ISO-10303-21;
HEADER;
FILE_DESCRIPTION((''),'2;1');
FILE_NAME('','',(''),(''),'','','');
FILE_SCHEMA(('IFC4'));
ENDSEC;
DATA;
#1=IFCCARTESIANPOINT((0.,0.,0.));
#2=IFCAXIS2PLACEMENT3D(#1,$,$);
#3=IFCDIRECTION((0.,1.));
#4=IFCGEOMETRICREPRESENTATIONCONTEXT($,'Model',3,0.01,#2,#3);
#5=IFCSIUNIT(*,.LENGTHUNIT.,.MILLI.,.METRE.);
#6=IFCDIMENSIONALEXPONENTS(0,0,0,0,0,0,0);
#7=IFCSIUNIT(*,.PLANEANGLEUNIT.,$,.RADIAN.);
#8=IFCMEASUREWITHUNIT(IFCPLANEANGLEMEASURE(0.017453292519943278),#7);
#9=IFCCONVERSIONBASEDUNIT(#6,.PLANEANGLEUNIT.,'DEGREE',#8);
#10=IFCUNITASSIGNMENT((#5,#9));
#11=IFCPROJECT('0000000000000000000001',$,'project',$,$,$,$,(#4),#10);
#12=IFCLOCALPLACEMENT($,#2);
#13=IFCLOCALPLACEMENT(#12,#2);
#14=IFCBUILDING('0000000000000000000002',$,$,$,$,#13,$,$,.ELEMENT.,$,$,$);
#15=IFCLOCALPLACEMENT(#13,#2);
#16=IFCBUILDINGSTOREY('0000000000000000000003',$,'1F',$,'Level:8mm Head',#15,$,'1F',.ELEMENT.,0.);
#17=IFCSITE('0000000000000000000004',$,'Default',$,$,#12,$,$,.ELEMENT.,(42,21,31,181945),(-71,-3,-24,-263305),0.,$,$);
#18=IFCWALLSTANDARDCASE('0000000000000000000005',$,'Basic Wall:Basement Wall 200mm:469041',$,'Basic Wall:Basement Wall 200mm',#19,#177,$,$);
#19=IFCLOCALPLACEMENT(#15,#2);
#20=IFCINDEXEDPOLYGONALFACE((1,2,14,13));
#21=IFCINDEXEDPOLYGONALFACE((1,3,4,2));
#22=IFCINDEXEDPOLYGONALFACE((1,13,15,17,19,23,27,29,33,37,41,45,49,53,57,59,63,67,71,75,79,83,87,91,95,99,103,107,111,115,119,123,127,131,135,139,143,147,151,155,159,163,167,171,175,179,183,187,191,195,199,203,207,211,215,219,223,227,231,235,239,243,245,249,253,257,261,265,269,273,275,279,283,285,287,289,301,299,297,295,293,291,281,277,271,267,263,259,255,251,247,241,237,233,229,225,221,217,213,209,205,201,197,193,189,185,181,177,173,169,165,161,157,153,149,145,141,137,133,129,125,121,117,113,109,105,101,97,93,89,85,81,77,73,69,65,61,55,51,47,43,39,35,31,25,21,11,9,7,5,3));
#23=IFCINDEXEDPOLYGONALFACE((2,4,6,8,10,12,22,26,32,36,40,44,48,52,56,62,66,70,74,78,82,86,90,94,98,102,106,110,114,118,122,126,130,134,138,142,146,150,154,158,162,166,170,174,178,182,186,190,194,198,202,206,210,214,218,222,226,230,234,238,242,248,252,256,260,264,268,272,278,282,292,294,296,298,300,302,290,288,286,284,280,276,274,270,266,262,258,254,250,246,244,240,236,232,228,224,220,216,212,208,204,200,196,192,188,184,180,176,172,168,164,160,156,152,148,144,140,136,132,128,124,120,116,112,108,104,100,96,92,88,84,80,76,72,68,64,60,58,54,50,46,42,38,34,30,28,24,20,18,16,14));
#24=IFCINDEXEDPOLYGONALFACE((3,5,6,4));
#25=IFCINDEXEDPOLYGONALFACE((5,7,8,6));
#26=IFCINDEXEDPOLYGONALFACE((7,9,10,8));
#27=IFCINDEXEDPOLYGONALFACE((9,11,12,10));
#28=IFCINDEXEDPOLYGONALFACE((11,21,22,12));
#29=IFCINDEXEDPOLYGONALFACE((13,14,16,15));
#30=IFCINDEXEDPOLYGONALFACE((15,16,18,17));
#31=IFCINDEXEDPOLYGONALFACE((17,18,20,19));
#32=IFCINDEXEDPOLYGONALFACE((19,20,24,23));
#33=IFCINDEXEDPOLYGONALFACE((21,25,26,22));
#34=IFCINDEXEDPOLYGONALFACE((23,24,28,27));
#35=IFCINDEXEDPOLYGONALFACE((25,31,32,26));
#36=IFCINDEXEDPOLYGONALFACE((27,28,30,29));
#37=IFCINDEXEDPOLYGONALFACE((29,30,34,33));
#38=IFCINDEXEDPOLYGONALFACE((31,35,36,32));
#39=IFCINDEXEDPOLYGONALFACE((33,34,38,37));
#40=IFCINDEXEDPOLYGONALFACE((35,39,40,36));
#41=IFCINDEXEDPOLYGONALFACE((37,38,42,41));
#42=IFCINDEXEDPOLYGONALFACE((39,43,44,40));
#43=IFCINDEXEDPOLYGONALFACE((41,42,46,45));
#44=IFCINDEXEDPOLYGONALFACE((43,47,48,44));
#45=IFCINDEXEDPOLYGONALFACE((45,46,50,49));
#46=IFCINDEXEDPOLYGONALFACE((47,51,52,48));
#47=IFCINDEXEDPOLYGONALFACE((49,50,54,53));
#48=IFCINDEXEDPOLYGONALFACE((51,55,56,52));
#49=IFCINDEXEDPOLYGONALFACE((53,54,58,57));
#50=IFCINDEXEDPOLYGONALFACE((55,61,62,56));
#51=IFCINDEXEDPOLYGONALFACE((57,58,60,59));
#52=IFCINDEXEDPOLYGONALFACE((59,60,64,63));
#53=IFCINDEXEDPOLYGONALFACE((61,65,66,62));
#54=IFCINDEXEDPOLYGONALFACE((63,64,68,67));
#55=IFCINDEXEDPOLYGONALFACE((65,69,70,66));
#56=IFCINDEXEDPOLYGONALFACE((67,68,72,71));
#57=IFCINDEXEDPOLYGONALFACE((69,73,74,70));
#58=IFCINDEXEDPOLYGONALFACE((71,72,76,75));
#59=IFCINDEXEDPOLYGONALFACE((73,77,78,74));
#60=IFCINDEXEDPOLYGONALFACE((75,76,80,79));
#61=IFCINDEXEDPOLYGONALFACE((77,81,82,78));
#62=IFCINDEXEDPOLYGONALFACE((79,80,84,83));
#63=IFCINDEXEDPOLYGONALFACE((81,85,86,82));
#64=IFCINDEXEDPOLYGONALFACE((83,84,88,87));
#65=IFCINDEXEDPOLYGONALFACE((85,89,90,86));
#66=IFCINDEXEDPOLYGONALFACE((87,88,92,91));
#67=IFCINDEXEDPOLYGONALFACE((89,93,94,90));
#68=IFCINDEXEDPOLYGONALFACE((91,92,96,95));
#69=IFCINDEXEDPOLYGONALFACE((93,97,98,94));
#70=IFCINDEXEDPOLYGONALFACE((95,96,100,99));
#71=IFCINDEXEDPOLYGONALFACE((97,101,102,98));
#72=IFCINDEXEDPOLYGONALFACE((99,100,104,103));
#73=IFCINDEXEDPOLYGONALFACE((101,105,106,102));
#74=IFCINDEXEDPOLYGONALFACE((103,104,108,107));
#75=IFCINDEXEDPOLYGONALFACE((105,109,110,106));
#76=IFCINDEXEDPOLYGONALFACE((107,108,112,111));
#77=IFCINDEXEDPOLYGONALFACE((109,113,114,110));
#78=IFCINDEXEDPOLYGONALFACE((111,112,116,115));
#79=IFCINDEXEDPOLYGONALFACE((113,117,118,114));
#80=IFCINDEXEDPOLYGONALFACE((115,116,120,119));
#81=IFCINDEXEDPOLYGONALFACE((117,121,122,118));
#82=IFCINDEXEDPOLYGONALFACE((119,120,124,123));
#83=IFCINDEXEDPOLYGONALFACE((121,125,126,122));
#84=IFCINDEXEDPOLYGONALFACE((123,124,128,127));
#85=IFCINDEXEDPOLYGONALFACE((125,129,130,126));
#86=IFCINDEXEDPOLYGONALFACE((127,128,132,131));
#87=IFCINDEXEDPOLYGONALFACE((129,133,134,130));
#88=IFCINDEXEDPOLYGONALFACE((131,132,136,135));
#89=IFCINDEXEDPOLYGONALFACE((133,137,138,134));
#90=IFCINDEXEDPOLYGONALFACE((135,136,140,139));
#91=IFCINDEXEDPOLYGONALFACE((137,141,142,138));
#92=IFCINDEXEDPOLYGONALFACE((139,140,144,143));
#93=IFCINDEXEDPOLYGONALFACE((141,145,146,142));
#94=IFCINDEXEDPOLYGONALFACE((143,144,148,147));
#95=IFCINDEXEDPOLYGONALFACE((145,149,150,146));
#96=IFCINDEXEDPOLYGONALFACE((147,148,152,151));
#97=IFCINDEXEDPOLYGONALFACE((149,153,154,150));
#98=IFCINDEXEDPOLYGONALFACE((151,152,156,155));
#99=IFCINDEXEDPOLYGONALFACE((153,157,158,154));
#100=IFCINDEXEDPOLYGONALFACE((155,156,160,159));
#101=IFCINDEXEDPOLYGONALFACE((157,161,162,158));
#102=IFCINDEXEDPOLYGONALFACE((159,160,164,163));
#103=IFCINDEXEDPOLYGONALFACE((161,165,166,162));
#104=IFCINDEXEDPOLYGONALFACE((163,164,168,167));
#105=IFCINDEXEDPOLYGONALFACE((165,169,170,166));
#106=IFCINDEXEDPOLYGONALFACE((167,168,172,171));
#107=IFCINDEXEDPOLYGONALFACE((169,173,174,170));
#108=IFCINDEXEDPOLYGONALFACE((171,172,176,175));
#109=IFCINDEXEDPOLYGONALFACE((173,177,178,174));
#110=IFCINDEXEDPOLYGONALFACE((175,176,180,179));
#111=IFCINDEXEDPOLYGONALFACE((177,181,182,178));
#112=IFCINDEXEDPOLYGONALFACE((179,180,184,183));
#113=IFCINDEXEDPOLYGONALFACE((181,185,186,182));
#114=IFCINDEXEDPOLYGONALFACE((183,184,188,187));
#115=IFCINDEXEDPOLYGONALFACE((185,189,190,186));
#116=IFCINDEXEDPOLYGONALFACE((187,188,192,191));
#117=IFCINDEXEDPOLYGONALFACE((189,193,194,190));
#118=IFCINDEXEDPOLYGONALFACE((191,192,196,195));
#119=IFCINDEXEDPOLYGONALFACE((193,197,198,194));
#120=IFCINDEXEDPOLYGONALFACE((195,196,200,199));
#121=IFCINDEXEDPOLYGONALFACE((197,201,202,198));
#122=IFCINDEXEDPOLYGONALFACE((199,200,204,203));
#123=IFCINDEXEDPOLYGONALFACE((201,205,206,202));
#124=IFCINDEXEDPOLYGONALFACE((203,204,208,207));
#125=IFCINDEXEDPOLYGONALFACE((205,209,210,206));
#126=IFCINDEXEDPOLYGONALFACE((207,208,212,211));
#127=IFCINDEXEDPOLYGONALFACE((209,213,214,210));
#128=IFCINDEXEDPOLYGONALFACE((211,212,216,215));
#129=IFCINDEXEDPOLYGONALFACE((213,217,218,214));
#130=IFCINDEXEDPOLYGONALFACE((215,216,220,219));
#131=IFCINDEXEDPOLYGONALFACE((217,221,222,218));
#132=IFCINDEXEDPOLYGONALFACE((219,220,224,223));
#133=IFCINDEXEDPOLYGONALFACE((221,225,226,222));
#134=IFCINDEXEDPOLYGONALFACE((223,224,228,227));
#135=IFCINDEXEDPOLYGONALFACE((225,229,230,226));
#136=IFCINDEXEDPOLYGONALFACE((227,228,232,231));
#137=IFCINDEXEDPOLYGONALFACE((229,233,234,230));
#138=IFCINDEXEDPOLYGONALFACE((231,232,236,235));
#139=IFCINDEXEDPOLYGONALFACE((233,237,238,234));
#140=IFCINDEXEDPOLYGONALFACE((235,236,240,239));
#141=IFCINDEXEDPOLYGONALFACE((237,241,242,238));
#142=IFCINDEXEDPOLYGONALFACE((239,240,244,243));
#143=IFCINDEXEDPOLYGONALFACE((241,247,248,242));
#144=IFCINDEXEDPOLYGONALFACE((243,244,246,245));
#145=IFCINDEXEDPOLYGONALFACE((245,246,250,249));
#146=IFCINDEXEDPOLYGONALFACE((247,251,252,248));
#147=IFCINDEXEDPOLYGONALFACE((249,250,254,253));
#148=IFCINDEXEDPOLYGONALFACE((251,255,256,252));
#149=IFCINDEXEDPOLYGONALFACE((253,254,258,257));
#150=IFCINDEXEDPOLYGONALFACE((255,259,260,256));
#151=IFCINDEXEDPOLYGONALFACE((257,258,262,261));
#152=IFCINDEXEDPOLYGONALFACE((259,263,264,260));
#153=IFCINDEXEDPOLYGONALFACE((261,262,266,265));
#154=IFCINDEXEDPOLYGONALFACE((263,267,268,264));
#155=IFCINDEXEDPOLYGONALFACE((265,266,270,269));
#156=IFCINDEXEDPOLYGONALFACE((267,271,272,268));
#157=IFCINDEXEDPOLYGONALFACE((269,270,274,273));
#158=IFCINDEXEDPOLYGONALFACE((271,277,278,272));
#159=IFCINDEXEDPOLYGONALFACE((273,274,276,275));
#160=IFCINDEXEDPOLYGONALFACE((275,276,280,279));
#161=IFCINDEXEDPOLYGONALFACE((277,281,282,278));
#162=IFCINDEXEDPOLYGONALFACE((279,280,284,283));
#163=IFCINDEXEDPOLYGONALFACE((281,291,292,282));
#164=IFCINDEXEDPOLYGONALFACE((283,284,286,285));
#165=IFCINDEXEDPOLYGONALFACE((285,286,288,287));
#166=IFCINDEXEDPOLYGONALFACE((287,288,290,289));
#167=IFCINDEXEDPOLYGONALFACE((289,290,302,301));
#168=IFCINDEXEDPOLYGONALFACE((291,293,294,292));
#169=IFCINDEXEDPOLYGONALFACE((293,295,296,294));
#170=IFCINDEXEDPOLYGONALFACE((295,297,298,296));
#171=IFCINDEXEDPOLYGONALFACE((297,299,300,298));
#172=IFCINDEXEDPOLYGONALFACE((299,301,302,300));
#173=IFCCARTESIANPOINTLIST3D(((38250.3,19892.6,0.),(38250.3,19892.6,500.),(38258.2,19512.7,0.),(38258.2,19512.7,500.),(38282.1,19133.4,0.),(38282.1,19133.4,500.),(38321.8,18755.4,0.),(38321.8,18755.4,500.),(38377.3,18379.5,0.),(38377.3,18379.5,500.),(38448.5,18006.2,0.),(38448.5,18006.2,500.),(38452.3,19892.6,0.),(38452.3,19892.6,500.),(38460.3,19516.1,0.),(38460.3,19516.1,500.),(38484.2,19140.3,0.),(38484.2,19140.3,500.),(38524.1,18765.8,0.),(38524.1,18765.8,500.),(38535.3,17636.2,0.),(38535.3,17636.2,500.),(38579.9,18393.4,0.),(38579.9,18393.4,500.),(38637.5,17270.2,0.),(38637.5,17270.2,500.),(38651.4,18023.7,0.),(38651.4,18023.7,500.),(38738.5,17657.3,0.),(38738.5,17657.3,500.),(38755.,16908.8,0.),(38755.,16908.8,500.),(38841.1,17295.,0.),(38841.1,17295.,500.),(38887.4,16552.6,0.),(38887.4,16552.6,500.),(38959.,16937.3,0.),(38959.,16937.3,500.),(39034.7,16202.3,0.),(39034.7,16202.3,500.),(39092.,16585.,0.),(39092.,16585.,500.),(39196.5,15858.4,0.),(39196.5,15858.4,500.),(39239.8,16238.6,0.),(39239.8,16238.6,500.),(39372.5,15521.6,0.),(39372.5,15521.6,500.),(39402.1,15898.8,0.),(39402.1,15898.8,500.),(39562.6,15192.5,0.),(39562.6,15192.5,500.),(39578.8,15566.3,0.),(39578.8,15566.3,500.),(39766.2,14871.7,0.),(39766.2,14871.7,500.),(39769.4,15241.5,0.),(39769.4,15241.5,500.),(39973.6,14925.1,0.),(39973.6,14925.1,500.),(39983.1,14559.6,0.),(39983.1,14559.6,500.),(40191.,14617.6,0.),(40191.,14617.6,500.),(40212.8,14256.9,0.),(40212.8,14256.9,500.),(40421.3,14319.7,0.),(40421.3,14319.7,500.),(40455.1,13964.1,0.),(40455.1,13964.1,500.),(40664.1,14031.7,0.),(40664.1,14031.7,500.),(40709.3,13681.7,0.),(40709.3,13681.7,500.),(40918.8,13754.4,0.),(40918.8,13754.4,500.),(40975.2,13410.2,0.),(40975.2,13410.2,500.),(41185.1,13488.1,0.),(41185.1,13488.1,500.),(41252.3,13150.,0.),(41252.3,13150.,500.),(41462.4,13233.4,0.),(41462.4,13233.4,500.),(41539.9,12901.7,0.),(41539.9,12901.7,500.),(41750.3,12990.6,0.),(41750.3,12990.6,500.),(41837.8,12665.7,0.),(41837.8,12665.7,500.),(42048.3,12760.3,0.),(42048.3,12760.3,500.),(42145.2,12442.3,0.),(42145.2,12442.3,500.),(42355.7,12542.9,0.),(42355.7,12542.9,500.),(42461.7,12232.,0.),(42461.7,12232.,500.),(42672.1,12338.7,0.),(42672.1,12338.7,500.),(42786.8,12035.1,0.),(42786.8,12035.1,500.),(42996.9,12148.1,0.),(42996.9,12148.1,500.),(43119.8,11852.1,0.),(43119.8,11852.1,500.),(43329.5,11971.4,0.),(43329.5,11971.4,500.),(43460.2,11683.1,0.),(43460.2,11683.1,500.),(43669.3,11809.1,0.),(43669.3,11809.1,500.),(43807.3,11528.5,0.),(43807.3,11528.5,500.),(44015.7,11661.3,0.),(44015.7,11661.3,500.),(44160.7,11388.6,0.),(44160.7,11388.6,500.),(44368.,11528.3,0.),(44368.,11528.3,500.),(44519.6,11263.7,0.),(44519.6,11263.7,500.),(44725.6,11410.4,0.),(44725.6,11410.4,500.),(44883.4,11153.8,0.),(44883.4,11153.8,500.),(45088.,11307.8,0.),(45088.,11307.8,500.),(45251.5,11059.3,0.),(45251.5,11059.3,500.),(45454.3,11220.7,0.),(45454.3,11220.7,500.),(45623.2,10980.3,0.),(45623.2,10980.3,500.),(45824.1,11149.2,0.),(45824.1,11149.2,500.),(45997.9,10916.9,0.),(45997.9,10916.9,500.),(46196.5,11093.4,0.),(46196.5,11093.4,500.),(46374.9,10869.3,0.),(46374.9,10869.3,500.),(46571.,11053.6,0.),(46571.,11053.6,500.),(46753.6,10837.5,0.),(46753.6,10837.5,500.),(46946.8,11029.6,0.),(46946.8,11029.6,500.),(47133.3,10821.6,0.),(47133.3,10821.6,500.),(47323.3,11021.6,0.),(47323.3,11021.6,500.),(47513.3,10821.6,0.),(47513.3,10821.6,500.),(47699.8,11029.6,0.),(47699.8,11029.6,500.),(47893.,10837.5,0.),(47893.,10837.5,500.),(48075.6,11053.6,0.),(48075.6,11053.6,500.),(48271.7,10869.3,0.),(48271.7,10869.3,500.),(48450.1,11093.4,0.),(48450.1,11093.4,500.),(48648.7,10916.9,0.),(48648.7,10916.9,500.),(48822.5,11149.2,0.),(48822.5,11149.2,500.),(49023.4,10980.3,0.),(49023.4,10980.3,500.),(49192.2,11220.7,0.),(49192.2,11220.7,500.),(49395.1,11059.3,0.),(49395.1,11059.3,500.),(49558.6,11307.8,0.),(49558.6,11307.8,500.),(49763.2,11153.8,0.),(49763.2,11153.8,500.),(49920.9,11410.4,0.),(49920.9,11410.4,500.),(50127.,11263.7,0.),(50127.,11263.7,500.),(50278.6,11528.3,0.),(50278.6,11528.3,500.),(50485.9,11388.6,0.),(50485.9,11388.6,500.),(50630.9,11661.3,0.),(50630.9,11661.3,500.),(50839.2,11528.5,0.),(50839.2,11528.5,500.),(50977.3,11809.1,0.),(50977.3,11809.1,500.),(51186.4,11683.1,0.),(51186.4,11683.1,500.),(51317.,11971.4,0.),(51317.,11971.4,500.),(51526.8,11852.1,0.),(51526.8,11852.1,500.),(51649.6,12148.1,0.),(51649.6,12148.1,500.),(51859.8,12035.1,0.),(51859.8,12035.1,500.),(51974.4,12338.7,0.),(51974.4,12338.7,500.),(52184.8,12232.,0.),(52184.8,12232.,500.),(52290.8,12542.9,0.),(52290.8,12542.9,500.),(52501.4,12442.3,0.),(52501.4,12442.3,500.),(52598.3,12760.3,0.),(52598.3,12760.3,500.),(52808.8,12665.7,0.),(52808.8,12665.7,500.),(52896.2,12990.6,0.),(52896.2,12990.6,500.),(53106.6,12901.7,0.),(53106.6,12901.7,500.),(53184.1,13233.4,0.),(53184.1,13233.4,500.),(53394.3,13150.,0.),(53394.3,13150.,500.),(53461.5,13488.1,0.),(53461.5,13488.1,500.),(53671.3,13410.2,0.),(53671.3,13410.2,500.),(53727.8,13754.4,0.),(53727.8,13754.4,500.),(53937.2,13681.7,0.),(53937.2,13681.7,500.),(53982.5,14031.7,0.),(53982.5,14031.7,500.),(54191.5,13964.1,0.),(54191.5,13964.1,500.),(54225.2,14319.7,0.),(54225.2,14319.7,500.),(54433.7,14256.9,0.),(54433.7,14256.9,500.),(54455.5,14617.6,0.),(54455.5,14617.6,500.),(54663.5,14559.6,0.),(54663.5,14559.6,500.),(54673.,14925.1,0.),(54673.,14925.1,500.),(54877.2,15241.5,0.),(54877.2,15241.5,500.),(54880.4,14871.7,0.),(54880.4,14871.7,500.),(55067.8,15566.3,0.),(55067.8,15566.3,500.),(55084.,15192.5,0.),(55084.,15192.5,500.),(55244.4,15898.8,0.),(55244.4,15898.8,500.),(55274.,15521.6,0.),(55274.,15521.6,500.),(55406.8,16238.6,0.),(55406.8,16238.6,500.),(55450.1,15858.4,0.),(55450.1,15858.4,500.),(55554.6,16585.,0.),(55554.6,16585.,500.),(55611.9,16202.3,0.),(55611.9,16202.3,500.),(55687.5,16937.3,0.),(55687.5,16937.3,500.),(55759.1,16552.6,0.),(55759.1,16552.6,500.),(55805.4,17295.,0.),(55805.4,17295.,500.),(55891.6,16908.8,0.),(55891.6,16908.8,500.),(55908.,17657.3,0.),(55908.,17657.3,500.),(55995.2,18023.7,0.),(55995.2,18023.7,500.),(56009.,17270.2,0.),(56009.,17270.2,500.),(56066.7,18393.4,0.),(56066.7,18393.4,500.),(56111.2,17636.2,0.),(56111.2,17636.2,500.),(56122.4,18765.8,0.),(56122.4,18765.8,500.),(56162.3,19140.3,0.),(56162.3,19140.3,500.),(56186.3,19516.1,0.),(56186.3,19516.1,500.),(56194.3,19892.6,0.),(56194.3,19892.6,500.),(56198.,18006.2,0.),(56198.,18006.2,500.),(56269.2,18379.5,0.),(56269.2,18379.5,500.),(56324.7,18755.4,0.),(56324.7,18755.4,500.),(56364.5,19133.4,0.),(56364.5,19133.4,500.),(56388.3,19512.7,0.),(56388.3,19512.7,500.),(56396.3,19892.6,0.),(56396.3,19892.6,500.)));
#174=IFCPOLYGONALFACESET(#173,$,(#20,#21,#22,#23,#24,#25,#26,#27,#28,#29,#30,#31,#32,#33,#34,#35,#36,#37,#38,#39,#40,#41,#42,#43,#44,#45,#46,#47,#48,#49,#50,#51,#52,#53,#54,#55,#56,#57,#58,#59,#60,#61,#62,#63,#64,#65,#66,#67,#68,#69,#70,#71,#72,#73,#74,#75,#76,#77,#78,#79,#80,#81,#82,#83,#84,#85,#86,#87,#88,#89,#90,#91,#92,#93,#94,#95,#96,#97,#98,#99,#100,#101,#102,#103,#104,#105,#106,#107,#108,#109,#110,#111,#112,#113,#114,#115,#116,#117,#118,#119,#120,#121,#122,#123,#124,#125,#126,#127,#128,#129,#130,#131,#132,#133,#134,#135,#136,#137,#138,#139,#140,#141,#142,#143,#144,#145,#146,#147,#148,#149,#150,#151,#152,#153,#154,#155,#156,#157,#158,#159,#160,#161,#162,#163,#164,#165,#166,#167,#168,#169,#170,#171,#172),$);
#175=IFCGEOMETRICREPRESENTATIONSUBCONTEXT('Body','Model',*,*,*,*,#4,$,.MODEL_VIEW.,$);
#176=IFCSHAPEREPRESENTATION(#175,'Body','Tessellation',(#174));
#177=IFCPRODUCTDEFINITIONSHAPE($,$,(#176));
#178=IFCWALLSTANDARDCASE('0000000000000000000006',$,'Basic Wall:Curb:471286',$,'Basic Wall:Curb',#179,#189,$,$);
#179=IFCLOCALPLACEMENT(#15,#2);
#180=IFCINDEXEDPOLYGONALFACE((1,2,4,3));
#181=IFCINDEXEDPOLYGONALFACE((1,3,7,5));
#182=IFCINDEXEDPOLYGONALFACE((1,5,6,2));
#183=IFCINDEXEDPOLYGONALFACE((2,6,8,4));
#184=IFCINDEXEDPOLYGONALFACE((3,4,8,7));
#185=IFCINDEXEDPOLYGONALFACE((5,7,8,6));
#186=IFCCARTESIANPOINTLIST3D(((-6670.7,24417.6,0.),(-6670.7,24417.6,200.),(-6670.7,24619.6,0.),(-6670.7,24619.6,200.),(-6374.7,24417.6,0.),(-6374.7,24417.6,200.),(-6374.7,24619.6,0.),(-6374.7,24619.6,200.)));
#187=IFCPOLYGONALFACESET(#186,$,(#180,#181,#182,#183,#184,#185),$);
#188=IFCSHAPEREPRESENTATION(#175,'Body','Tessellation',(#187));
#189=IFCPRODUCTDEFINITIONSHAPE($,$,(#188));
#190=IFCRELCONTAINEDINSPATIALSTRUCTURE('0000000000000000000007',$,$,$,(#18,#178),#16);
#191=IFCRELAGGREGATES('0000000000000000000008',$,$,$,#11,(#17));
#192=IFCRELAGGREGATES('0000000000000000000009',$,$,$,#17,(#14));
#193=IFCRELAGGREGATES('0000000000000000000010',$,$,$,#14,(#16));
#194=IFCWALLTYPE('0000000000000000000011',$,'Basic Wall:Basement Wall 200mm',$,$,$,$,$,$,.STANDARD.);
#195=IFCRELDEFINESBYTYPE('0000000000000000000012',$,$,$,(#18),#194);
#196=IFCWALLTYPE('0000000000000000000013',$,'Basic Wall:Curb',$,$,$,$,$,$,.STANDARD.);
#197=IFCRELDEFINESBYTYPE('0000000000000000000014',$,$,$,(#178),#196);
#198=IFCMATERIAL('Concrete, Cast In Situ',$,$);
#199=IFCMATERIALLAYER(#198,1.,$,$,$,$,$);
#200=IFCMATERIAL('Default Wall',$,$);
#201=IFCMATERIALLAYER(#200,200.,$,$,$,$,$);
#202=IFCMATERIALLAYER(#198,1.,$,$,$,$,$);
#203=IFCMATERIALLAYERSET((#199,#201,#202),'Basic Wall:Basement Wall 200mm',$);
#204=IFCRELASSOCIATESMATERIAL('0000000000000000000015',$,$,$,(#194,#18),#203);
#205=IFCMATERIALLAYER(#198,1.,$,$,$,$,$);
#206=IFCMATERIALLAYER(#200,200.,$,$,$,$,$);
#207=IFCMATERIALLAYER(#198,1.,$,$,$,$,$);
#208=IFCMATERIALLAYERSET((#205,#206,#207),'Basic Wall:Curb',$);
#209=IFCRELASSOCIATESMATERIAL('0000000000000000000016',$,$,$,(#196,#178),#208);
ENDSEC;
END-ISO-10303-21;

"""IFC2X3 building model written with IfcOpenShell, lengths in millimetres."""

from ifc_helpers import new_model, entity, si_unit, converted_unit, direction, frame, frame_2d, origin, place, context, subcontext, project, spatial, polyline, circle_curve, parameter, trimmed, segment, composite_curve, rectangle, outline, extrude, material, layer, layer_set, layer_usage, type_object, element, save


model = new_model("IFC2X3")

# Units and contexts
model_context = context("Model", 3, precision=0.01, world=origin(), true_north=direction((0.0, 1.0)))
body_context = subcontext(model_context, "Body", "Model", "MODEL_VIEW")
ifc_project = project(units=[si_unit("LENGTHUNIT", "METRE", prefix="MILLI"), converted_unit("PLANEANGLEUNIT", "DEGREE", entity("IfcPlaneAngleMeasure", 0.017453292519943278), si_unit("PLANEANGLEUNIT", "RADIAN"), dimensions=[0, 0, 0, 0, 0, 0, 0])], contexts=[model_context])

# Site, building, storey
site_placement = place(None, origin())
site = spatial("IfcSite", under=ifc_project, at=site_placement, Name="Default", CompositionType="ELEMENT", RefLatitude=(42, 21, 31, 181945), RefLongitude=(-71, -3, -24, -263305), RefElevation=0.0)
building_placement = place(site_placement, origin())
building = spatial("IfcBuilding", under=site, at=building_placement, CompositionType="ELEMENT")
storey_placement = place(building_placement, origin())
storey = spatial("IfcBuildingStorey", under=building, at=storey_placement, Name="1F", ObjectType="Level:8mm Head", LongName="1F", CompositionType="ELEMENT", Elevation=0.0)

# Shared definitions
ifc_material_1 = material(Name="Default Wall")

# Walls
ifc_material_2 = material(Name="Concrete, Cast In Situ")
ifc_layer_1 = layer(ifc_material_2, 1.0)
ifc_layer_2 = layer(ifc_material_1, 200.0)
ifc_layer_3 = layer(ifc_material_2, 1.0)
ifc_layer_set_1 = layer_set([ifc_layer_1, ifc_layer_2, ifc_layer_3], Name="Basic Wall:Basement Wall 200mm")
wall_type_1 = type_object("IfcWallType", Name="Basic Wall:Basement Wall 200mm", PredefinedType="STANDARD", material=ifc_layer_set_1)
ifc_layer_usage_1 = layer_usage(ifc_layer_set_1, "AXIS2", "NEGATIVE", 101.0)
wall_1_placement = place(storey_placement, frame((38351.3, 19892.6, 0.0)))
element("IfcWallStandardCase", 1, at=wall_1_placement, inside=storey, type_object=wall_type_1, material=ifc_layer_usage_1, Name="Basic Wall:Basement Wall 200mm:469041", ObjectType="Basic Wall:Basement Wall 200mm", context=body_context, shape_type="SweptSolid", body=[
    extrude(outline(composite_curve([segment(trimmed(circle_curve(frame_2d((8972.0, 0.0), x_axis=(1.0, 0.0)), 8871.0), [parameter(180.0)], [parameter(0.0)], True, "PARAMETER"), False, "CONTINUOUS"), segment(polyline([(101.0, 0.0), (-101.0, 0.0)]), True, "CONTINUOUS"), segment(trimmed(circle_curve(frame_2d((8972.0, 0.0), x_axis=(1.0, 0.0)), 9073.0), [parameter(180.0)], [parameter(0.0)], True, "PARAMETER"), True, "CONTINUOUS"), segment(polyline([(18045.0, 0.0), (17843.0, 0.0)]), True, "CONTINUOUS")], self_intersect=False)), origin(), (0.0, 0.0, 1.0), 500.0),
])
ifc_layer_4 = layer(ifc_material_2, 1.0)
ifc_layer_5 = layer(ifc_material_1, 200.0)
ifc_layer_6 = layer(ifc_material_2, 1.0)
ifc_layer_set_2 = layer_set([ifc_layer_4, ifc_layer_5, ifc_layer_6], Name="Basic Wall:Curb")
wall_type_2 = type_object("IfcWallType", Name="Basic Wall:Curb", PredefinedType="STANDARD", material=ifc_layer_set_2)
ifc_layer_usage_2 = layer_usage(ifc_layer_set_2, "AXIS2", "NEGATIVE", 101.0)
wall_2_placement = place(storey_placement, frame((-6374.7, 24518.6, 0.0), z_axis=(0.0, 0.0, 1.0), x_axis=(-1.0, 0.0, 0.0)))
element("IfcWallStandardCase", 2, at=wall_2_placement, inside=storey, type_object=wall_type_2, material=ifc_layer_usage_2, Name="Basic Wall:Curb:471286", ObjectType="Basic Wall:Curb", context=body_context, shape_type="SweptSolid", body=[
    extrude(rectangle(XDim=296.0, YDim=202.0, at=frame_2d((148.0, 0.0), x_axis=(-1.0, 0.0))), origin(), (0.0, 0.0, 1.0), 200.0),
])

save(model, "model.ifc")
